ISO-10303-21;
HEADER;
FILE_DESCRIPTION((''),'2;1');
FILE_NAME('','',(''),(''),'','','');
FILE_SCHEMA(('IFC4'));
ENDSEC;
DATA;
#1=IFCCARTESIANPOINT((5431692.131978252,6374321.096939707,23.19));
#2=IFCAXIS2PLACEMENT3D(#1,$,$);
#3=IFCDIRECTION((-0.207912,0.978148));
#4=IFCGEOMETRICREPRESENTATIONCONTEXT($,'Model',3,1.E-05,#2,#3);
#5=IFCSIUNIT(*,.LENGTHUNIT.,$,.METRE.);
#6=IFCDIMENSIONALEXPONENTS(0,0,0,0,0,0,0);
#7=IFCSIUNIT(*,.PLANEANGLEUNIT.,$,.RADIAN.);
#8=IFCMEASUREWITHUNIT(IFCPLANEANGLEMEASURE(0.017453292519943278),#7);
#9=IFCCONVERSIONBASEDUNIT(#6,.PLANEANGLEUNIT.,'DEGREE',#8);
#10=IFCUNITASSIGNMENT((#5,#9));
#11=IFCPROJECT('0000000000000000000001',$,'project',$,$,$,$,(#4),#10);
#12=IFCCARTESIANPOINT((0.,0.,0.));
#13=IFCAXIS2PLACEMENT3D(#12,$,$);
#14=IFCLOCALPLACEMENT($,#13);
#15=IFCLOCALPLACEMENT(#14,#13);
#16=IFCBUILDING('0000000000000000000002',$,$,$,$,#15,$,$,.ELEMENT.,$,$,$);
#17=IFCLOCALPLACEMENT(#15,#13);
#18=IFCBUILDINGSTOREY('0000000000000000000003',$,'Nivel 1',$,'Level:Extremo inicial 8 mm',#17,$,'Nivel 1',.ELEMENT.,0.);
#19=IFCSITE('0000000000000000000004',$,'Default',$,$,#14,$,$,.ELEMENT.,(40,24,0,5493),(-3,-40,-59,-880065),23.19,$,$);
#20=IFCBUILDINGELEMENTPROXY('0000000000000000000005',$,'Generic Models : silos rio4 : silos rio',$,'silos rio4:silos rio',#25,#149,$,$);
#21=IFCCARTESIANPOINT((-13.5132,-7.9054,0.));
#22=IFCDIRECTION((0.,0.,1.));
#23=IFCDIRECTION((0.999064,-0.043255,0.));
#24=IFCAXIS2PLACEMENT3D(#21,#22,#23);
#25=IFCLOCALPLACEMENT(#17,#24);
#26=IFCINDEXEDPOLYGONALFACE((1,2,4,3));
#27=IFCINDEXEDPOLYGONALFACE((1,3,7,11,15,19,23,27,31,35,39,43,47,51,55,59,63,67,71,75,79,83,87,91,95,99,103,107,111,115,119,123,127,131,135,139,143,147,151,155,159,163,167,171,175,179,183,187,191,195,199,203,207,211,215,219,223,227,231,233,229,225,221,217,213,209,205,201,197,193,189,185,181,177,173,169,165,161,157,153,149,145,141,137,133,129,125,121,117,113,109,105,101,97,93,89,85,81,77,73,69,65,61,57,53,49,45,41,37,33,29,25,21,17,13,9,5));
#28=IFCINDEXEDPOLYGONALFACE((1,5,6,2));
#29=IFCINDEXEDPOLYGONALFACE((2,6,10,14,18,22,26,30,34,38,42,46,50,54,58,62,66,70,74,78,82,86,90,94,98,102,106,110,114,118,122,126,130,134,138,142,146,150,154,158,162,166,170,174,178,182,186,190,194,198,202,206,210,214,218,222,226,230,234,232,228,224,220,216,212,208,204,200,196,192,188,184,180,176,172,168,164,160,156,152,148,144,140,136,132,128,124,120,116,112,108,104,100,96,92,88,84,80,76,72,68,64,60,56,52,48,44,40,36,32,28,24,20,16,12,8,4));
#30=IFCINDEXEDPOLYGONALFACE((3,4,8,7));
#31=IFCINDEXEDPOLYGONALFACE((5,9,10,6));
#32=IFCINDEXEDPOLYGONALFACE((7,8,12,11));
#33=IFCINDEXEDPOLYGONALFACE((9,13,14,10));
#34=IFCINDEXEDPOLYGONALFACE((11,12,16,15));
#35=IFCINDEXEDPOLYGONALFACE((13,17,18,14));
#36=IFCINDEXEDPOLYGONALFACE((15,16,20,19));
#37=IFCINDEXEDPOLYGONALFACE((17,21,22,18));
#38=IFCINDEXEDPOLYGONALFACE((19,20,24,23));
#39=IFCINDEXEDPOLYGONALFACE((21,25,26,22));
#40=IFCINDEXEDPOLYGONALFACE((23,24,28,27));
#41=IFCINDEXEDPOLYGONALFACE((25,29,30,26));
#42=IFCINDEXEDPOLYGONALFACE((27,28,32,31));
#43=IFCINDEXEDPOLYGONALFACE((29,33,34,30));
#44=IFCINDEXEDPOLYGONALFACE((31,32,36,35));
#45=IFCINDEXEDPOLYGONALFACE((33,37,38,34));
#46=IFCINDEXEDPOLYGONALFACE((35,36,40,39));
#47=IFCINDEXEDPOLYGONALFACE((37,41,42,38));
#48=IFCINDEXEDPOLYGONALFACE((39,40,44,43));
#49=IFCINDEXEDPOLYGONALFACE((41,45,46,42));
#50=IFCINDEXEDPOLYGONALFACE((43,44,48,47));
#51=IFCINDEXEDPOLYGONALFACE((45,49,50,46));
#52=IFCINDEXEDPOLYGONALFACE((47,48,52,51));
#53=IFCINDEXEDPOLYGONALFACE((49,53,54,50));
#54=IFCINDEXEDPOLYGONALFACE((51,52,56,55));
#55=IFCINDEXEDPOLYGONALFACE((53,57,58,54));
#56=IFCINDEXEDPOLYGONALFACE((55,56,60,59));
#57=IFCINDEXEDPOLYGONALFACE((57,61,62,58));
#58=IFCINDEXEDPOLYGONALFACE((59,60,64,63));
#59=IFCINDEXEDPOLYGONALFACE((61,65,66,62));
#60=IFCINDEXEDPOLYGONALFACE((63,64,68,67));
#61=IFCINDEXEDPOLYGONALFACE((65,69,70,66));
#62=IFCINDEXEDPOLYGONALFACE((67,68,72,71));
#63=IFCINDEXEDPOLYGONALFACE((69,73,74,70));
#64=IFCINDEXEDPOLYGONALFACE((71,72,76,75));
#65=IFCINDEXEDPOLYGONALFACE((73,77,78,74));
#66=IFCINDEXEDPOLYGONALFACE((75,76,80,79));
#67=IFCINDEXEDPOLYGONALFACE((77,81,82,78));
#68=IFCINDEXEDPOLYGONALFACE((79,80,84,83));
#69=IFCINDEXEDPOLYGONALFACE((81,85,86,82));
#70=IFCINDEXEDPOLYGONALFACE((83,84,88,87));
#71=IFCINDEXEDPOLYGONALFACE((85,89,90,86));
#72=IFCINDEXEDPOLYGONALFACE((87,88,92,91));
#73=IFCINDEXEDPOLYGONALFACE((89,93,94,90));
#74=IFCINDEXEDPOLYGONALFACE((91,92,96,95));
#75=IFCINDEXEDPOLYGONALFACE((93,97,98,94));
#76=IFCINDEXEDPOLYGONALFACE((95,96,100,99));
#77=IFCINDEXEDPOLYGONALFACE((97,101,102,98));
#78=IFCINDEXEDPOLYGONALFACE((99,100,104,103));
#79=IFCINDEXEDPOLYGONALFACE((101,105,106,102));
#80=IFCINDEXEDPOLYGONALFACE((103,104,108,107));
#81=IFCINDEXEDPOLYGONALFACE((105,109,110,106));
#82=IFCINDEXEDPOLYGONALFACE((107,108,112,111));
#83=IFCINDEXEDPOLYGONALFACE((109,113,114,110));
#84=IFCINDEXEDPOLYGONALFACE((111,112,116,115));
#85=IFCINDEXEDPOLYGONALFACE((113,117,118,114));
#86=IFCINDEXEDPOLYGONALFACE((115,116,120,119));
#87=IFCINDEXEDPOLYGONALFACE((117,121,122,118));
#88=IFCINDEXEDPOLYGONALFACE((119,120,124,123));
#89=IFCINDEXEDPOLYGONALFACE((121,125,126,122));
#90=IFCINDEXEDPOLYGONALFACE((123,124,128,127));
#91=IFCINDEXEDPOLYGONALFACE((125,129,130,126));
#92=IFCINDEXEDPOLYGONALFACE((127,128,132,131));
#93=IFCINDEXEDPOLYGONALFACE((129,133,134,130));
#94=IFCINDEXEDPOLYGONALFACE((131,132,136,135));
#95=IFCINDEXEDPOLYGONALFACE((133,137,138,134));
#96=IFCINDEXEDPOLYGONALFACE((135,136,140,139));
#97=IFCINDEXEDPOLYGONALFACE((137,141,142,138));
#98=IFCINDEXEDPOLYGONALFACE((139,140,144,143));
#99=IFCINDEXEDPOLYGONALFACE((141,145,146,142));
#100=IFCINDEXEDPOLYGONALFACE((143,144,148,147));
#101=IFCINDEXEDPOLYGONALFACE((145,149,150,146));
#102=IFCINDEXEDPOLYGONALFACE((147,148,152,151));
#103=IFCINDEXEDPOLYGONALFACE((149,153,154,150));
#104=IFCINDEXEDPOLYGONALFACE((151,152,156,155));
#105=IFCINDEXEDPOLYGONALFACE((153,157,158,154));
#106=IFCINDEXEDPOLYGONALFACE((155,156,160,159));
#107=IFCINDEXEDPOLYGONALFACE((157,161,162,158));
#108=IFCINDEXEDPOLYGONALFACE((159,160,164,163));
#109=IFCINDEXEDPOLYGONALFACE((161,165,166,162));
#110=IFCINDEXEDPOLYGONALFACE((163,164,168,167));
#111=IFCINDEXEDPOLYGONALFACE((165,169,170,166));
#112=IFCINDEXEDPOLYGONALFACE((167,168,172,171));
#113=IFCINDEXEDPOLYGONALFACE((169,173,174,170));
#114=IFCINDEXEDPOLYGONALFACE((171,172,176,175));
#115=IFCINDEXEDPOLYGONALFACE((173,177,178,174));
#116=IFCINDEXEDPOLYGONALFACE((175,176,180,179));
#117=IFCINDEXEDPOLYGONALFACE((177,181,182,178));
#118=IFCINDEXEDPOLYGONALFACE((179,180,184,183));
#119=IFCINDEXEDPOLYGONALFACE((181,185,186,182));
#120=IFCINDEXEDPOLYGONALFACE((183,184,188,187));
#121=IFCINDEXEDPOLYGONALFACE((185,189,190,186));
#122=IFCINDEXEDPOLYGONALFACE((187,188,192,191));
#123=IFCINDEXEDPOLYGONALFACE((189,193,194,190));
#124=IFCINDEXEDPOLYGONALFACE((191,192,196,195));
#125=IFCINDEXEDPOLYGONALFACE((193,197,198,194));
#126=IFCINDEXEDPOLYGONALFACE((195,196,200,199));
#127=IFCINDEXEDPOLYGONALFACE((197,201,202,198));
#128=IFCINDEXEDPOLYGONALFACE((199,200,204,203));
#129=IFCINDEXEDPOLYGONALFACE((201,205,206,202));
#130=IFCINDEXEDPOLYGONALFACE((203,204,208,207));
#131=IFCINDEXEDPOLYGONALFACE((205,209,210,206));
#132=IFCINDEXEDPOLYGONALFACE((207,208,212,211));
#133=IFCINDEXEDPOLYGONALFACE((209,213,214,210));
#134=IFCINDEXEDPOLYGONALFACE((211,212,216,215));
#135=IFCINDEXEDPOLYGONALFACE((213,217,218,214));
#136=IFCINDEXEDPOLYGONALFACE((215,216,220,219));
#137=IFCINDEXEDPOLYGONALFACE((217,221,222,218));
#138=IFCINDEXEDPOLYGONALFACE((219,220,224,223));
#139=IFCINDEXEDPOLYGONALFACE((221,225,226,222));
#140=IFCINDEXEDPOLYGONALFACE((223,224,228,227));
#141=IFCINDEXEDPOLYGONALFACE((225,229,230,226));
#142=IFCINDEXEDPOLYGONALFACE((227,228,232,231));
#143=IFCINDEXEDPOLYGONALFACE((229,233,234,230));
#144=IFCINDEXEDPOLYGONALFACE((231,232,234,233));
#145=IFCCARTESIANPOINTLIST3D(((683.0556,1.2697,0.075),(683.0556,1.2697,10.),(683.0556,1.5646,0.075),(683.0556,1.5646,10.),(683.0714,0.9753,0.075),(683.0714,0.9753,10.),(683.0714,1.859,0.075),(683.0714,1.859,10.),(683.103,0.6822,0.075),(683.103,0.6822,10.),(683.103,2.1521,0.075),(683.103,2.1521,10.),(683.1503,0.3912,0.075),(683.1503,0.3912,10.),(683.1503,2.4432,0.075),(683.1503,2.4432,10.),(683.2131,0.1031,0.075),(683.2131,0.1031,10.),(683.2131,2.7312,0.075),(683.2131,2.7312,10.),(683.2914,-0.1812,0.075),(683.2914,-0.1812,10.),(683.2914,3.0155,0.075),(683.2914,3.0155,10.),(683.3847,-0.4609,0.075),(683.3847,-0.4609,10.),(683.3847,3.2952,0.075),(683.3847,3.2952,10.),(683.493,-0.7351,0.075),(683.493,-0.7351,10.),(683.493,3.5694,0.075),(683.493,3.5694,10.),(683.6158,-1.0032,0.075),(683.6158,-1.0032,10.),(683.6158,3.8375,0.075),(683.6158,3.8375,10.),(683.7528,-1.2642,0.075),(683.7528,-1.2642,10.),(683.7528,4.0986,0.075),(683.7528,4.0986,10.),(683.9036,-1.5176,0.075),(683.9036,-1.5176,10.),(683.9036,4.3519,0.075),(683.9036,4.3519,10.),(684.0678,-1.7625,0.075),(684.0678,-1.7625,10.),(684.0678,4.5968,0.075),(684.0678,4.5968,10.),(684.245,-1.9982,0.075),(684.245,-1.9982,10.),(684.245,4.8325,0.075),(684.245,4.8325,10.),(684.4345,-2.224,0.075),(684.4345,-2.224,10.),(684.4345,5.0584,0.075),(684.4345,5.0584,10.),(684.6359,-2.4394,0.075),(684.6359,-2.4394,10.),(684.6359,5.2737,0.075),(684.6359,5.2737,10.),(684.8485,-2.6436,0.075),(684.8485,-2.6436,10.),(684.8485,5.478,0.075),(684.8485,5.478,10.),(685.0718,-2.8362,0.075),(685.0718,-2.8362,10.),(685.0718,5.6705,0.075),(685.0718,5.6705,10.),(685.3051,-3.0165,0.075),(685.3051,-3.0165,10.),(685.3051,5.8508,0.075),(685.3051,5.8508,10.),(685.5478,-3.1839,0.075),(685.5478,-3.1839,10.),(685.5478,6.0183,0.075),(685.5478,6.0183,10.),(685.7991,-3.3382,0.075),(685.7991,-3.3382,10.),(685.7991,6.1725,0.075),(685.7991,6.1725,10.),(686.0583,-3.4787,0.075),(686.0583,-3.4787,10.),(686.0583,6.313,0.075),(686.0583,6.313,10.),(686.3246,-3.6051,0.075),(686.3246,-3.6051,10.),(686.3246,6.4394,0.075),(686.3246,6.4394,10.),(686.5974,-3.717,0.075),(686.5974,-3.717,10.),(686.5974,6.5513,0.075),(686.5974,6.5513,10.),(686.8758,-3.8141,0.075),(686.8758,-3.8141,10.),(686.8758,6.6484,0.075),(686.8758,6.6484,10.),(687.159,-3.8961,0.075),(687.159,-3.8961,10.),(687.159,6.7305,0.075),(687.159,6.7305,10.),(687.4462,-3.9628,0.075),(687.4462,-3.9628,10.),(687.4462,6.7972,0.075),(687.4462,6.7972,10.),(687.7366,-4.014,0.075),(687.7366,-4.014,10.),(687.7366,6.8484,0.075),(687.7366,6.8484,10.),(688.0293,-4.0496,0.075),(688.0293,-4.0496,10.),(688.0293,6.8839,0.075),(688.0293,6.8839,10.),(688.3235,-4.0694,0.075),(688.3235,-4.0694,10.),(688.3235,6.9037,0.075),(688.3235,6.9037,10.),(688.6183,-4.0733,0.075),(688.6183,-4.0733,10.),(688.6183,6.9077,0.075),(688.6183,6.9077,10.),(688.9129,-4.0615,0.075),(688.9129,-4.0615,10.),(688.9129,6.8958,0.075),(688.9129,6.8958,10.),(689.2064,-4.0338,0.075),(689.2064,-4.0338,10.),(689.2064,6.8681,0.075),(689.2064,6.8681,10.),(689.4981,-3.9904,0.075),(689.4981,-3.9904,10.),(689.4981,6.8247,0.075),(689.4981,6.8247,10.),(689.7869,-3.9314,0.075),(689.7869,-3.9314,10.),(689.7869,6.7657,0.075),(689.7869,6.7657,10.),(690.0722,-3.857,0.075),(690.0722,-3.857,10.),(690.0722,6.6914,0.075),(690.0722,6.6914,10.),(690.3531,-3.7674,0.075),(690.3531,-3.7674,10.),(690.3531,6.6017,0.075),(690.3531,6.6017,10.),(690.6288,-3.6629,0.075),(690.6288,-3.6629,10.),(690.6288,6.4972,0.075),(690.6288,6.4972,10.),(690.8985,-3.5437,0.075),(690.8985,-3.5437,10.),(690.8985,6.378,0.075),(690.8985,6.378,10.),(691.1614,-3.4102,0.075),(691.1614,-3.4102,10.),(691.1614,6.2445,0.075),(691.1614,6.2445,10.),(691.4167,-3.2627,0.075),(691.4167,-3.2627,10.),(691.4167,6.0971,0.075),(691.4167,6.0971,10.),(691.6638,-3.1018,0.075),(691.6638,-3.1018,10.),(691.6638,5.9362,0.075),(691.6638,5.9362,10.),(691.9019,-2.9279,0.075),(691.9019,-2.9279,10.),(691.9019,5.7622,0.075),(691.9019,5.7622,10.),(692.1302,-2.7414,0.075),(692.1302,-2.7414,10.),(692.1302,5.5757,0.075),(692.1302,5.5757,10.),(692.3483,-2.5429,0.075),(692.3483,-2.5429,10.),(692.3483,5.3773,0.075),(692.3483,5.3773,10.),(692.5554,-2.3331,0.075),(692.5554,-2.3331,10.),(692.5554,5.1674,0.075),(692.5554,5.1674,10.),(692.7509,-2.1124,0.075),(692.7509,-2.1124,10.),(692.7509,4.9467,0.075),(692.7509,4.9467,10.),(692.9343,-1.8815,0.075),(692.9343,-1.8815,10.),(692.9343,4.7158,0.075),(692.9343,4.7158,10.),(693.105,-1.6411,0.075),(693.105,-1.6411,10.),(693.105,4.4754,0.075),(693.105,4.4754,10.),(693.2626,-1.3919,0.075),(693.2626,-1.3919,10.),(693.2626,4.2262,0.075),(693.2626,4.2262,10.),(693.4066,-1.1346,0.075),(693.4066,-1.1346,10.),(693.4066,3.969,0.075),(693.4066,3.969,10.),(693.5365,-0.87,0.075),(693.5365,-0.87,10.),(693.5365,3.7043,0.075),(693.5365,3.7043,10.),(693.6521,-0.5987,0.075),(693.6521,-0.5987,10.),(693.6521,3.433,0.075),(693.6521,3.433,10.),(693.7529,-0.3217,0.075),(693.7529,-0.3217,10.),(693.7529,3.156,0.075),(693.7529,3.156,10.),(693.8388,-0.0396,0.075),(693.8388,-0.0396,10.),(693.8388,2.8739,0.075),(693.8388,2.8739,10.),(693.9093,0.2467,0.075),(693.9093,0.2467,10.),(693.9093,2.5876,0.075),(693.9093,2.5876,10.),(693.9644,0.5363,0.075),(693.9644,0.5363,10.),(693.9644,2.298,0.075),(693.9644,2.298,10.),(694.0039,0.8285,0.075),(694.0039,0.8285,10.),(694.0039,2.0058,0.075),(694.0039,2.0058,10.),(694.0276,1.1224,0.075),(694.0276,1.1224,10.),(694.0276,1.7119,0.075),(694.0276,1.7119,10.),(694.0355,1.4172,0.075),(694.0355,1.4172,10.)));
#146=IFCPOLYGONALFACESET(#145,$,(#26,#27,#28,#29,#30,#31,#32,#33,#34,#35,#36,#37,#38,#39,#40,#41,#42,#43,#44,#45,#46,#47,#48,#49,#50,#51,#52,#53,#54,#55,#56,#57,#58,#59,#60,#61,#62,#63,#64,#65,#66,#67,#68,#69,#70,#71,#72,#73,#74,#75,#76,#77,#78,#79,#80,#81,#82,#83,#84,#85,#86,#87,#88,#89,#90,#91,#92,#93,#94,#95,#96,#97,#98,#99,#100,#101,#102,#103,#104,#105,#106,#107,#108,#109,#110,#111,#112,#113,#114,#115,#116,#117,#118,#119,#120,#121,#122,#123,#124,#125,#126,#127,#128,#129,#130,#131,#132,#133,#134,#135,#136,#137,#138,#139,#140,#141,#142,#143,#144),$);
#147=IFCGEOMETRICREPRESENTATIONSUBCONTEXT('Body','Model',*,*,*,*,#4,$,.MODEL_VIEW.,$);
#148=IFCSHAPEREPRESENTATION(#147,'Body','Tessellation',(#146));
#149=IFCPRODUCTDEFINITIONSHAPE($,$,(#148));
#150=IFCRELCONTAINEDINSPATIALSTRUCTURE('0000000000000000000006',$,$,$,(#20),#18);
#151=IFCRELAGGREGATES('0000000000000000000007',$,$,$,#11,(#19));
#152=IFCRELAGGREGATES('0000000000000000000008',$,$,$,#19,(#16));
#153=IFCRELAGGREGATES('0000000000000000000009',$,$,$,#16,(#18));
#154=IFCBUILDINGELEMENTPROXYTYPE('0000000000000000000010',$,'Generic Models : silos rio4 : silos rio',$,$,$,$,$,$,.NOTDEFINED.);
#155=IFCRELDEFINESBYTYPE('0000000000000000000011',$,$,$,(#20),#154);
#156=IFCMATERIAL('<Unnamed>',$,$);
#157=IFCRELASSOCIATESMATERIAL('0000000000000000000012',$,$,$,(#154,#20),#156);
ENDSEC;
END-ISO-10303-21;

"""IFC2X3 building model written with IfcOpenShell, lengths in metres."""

from ifc_helpers import new_model, entity, si_unit, converted_unit, direction, frame, frame_2d, origin, place, context, subcontext, project, spatial, circle, extrude, source, transform, mapped, material, type_object, type_shapes, element, save


model = new_model("IFC2X3")

# Units and contexts
model_context = context("Model", 3, precision=1e-05, world=frame((5431692.131978252, 6374321.096939707, 23.19)), true_north=direction((-0.207912, 0.978148)))
body_context = subcontext(model_context, "Body", "Model", "MODEL_VIEW")
ifc_project = project(units=[si_unit("LENGTHUNIT", "METRE"), converted_unit("PLANEANGLEUNIT", "DEGREE", entity("IfcPlaneAngleMeasure", 0.017453292519943278), si_unit("PLANEANGLEUNIT", "RADIAN"), dimensions=[0, 0, 0, 0, 0, 0, 0])], contexts=[model_context])

# Site, building, storey
site_placement = place(None, origin())
site = spatial("IfcSite", under=ifc_project, at=site_placement, Name="Default", CompositionType="ELEMENT", RefLatitude=(40, 24, 0, 5493), RefLongitude=(-3, -40, -59, -880065), RefElevation=23.19)
building_placement = place(site_placement, origin())
building = spatial("IfcBuilding", under=site, at=building_placement, CompositionType="ELEMENT")
storey_placement = place(building_placement, origin())
storey = spatial("IfcBuildingStorey", under=building, at=storey_placement, Name="Nivel 1", ObjectType="Level:Extremo inicial 8 mm", LongName="Nivel 1", CompositionType="ELEMENT", Elevation=0.0)

# Building element proxy
ifc_material_1 = material(Name="<Unnamed>")
building_element_proxy_type_1 = type_object("IfcBuildingElementProxyType", Name="Generic Models : silos rio4 : silos rio", PredefinedType="NOTDEFINED", material=ifc_material_1)
shared_shape_1 = source(origin(), body_context, "Body", "SweptSolid", [
    extrude(circle(Radius=5.491, at=frame_2d((0.0, 0.0), x_axis=(1.0, 0.0))), frame((688.5446, 1.4172, 0.075)), (0.0, 0.0, 1.0), 9.925),
])
type_shapes(building_element_proxy_type_1, [shared_shape_1])
proxy_1_placement = place(storey_placement, frame((-13.5132, -7.9054, 0.0), z_axis=(0.0, 0.0, 1.0), x_axis=(0.999064, -0.043255, 0.0)))
element("IfcBuildingElementProxy", 1, at=proxy_1_placement, inside=storey, type_object=building_element_proxy_type_1, material=ifc_material_1, Name="Generic Models : silos rio4 : silos rio", ObjectType="silos rio4:silos rio", context=body_context, shape_type="MappedRepresentation", body=[
    mapped(shared_shape_1, transform((0.0, 0.0, 0.0), scale=1.0)),
])

save(model, "model.ifc")
